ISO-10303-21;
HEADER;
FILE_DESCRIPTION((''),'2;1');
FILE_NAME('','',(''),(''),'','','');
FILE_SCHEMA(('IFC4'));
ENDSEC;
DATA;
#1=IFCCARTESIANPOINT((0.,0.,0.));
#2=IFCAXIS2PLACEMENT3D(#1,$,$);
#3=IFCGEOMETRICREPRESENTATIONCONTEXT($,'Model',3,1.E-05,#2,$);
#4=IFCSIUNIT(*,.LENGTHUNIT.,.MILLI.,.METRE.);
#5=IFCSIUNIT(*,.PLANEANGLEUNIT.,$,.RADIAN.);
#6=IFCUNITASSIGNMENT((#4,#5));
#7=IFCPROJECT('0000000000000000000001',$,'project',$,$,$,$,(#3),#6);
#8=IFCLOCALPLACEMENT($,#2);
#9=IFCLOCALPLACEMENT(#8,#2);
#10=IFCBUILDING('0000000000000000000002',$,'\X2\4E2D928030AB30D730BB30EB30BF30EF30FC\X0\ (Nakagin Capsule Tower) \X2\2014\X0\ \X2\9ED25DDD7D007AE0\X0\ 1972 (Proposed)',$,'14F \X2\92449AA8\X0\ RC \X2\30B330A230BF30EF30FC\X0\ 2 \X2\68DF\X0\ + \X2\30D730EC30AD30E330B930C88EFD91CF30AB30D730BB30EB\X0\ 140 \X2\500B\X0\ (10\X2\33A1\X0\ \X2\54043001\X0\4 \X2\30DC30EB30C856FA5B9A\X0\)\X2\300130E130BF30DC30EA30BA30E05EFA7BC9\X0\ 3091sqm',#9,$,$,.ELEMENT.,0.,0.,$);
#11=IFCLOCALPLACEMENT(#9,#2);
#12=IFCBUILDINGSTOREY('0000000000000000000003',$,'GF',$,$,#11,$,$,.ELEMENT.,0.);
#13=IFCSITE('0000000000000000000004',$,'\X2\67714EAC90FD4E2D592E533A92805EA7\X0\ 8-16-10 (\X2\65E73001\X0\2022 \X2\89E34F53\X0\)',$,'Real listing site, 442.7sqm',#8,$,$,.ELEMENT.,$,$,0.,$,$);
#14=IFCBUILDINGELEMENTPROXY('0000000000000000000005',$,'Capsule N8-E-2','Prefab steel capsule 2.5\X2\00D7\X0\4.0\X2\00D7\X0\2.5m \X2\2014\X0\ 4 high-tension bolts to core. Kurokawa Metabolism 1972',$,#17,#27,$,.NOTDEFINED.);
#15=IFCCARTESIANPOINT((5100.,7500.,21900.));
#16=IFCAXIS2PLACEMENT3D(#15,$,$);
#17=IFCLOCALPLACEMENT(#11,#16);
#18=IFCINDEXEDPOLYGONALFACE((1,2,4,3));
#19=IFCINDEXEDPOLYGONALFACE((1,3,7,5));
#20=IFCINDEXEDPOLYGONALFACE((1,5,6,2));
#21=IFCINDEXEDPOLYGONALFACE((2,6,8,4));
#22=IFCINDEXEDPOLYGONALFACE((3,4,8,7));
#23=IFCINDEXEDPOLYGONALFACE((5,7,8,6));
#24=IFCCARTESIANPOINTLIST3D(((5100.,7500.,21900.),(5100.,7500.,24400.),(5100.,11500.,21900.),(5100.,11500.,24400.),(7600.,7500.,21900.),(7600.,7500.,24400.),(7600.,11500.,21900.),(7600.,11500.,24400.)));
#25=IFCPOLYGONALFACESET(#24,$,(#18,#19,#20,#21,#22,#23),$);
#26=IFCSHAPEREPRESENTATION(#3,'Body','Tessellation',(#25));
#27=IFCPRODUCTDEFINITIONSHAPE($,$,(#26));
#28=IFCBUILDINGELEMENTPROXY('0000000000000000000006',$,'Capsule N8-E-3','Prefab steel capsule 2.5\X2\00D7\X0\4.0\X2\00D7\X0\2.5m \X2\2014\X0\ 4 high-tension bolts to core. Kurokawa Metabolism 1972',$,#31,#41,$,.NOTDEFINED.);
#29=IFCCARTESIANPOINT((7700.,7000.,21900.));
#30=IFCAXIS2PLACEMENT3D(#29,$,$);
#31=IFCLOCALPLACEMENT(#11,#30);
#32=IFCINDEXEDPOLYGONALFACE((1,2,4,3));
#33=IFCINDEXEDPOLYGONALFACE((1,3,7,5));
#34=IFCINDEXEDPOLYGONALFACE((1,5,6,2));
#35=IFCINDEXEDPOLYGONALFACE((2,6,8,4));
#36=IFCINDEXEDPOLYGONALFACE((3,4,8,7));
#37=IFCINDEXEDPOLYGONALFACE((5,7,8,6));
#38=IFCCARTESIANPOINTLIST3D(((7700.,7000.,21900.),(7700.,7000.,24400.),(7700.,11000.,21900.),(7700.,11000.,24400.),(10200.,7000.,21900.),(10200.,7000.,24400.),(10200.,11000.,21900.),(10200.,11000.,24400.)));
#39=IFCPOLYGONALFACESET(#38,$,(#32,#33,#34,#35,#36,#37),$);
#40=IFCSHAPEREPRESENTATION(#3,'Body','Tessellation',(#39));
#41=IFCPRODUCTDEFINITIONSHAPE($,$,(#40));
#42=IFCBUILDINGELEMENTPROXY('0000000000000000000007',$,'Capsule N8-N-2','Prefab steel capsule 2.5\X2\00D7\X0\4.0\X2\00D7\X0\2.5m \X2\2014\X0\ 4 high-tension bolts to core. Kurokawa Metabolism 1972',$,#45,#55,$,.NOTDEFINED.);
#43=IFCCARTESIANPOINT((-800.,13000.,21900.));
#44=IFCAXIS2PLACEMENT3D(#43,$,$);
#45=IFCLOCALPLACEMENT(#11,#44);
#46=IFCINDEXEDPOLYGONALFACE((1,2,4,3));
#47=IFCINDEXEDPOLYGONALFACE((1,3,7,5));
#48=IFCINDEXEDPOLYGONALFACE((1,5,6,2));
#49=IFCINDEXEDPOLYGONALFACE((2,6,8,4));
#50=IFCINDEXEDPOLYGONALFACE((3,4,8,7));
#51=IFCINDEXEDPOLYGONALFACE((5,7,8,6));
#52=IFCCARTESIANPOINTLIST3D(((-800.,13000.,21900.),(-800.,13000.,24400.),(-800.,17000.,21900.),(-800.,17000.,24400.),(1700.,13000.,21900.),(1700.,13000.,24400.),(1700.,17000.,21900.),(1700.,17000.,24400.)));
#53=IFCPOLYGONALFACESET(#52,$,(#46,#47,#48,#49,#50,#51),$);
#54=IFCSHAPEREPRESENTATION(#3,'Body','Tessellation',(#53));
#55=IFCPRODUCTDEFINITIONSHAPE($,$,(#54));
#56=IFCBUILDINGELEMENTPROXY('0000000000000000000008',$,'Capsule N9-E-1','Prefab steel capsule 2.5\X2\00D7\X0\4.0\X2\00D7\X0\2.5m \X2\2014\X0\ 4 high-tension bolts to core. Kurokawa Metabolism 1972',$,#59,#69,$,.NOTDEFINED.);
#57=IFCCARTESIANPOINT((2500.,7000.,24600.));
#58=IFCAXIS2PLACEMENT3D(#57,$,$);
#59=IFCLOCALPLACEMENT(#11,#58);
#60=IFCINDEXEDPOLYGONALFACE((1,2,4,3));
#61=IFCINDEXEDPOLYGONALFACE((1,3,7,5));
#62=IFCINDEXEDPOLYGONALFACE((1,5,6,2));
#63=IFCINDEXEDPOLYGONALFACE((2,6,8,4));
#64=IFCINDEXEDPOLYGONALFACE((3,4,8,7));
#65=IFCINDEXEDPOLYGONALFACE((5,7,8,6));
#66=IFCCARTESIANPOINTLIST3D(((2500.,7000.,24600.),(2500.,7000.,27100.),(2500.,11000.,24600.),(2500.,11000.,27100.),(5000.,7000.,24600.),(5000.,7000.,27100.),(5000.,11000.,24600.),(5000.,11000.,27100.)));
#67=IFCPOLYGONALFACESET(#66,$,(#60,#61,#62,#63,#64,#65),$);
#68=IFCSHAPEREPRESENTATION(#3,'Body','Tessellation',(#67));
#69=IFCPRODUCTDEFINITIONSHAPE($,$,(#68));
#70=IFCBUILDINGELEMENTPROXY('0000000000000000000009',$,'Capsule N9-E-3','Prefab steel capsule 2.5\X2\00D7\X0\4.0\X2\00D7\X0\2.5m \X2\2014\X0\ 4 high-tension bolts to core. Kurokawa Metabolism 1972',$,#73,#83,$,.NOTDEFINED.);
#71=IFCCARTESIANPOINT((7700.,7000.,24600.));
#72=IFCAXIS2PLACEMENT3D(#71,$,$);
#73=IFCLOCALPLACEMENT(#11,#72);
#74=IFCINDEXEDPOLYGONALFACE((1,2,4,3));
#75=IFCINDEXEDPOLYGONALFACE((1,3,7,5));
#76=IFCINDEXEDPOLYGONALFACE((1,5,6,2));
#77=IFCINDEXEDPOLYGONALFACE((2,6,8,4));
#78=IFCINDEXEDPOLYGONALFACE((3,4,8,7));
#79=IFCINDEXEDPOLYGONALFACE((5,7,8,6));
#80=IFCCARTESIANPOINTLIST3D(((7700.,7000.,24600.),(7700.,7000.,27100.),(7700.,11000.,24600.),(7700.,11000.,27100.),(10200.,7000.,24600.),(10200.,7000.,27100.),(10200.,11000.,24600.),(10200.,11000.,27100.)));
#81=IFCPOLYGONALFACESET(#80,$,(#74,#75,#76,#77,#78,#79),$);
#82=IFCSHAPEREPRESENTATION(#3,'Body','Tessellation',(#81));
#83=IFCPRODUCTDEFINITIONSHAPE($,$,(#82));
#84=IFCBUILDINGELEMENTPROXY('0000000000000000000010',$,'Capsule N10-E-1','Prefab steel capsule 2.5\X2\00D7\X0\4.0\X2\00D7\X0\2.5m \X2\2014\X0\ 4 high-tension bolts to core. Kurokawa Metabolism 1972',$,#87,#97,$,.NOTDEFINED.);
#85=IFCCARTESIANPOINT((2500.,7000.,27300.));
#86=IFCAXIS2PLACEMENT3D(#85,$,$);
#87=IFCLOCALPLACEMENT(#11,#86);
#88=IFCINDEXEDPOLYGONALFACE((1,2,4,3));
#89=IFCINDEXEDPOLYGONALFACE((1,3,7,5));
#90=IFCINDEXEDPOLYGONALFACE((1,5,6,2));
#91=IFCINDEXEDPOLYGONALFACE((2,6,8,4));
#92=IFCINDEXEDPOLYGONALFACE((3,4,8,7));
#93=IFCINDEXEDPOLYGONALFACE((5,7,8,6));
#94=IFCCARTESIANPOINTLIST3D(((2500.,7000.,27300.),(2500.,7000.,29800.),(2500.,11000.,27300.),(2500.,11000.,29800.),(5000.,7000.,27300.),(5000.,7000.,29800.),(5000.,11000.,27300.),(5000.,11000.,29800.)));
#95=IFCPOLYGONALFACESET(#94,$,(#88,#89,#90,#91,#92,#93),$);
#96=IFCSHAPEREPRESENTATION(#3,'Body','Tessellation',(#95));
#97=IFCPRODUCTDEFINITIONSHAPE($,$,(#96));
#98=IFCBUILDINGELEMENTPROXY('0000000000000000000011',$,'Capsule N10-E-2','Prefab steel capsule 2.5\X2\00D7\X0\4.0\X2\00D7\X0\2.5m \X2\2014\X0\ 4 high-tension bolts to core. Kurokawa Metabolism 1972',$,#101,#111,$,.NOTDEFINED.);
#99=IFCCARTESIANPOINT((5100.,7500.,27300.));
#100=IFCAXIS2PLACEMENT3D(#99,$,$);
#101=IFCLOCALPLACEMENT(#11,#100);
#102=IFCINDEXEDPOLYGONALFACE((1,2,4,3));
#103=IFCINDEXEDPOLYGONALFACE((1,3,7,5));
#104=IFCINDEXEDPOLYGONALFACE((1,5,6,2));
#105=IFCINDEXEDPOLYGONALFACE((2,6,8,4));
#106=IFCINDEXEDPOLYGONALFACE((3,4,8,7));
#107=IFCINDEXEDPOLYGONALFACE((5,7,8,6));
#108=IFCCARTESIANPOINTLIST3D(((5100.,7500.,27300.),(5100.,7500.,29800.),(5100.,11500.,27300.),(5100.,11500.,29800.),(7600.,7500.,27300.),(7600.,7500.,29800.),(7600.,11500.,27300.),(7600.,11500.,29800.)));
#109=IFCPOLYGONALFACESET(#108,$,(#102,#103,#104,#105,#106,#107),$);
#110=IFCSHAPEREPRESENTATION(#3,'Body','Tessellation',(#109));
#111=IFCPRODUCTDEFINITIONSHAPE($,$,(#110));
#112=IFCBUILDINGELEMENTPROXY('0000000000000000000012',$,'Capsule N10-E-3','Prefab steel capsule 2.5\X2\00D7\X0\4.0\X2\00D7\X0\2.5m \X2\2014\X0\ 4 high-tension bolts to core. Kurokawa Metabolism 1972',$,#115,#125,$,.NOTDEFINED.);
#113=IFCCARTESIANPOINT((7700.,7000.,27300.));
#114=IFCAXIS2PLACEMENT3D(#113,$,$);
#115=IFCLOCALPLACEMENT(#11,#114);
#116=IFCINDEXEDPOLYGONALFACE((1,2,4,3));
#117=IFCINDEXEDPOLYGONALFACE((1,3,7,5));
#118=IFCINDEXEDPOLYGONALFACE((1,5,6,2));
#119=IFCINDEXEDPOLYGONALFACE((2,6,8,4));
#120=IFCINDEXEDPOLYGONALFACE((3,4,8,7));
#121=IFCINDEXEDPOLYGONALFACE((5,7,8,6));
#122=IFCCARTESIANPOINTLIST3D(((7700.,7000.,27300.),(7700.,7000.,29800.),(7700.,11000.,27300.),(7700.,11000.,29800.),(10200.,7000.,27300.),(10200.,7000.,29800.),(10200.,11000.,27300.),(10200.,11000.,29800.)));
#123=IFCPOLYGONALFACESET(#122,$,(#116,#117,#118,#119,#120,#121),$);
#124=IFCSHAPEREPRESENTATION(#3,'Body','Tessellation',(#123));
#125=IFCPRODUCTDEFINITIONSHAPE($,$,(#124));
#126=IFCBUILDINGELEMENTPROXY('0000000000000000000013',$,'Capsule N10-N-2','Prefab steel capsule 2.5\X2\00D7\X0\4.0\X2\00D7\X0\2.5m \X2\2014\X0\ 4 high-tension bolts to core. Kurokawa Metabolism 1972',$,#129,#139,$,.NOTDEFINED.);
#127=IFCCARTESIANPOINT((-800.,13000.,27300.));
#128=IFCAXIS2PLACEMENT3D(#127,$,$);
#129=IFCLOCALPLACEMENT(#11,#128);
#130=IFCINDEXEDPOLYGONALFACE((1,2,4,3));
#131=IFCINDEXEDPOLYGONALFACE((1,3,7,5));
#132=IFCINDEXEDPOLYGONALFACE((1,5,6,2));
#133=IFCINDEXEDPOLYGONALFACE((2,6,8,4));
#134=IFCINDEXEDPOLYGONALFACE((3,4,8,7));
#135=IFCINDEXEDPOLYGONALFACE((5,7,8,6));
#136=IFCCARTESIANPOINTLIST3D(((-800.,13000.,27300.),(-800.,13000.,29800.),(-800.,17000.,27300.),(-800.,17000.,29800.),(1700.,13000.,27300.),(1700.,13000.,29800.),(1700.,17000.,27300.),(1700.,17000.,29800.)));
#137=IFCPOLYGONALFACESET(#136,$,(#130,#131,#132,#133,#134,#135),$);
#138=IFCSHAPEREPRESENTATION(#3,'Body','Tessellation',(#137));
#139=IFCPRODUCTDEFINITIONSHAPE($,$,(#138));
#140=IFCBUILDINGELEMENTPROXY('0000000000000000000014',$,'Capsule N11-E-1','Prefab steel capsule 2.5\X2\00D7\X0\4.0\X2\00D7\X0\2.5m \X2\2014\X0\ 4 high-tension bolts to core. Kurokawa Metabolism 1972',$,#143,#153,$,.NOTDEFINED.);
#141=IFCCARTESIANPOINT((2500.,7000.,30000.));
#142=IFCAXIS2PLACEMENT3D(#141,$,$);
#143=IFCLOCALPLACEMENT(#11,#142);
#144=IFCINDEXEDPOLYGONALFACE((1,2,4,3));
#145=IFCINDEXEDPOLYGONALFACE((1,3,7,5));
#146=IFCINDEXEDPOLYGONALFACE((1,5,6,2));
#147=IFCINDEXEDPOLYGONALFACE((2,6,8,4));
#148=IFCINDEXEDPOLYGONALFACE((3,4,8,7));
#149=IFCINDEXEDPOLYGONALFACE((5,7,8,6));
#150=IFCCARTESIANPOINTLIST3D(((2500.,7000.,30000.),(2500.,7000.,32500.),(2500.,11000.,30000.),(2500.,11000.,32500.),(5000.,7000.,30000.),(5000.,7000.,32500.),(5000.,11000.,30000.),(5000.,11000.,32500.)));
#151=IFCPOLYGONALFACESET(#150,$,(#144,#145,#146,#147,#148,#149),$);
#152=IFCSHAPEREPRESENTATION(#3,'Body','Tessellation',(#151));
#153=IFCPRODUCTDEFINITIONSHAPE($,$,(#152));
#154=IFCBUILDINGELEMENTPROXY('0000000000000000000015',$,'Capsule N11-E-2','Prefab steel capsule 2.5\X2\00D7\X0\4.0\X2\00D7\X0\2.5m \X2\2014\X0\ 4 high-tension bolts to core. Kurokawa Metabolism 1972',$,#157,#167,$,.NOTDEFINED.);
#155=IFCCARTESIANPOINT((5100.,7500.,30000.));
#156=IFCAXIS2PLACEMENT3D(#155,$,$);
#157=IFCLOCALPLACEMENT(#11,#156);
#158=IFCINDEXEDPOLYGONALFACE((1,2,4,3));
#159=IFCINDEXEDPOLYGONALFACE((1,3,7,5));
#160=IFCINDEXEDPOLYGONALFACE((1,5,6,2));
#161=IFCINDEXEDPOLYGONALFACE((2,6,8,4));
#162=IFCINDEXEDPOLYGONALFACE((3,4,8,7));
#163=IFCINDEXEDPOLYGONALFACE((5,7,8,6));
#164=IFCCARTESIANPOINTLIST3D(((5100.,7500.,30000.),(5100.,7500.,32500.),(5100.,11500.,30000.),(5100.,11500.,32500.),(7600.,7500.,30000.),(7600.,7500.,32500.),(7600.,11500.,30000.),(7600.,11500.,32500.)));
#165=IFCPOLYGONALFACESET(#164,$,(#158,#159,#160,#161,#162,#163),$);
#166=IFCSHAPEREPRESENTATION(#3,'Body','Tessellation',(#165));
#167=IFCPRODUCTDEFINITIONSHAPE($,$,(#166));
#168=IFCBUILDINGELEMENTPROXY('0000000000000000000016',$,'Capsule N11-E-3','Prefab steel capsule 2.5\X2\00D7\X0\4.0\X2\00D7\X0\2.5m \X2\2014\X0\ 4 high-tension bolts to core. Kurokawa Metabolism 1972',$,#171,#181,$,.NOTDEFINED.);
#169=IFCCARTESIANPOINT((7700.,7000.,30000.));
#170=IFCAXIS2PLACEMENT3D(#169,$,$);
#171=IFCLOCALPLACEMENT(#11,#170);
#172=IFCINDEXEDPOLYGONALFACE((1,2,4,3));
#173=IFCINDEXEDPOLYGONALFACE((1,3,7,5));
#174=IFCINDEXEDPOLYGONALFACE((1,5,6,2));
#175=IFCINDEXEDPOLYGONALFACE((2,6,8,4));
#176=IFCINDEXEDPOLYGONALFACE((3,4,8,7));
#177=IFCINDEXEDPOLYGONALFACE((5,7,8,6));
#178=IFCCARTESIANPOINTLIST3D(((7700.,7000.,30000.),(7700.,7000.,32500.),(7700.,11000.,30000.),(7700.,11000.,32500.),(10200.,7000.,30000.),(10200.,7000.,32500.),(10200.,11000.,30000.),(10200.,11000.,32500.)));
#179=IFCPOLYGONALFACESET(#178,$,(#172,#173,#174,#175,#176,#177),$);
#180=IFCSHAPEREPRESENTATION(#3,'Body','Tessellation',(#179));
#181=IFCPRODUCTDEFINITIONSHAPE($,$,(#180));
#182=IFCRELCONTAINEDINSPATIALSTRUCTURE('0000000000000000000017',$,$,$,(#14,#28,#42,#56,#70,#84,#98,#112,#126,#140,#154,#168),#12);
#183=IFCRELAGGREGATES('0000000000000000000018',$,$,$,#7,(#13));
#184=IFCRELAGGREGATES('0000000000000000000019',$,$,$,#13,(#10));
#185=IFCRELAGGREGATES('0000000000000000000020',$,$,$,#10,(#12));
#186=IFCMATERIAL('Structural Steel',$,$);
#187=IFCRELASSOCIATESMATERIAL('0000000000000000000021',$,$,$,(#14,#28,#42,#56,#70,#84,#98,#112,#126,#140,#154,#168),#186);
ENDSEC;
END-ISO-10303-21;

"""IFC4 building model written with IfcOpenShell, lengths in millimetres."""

from ifc_helpers import new_model, si_unit, frame, frame_2d, origin, place, context, project, spatial, rectangle, extrude, material, element, save


model = new_model("IFC4")

# Units and contexts
model_context = context("Model", 3, precision=1e-05, world=origin())
ifc_project = project(units=[si_unit("LENGTHUNIT", "METRE", prefix="MILLI"), si_unit("PLANEANGLEUNIT", "RADIAN")], contexts=[model_context])

# Site, building, storey
site_placement = place(None, origin())
site = spatial("IfcSite", under=ifc_project, at=site_placement, Name="東京都中央区銀座 8-16-10 (旧、2022 解体)", ObjectType="Real listing site, 442.7sqm", CompositionType="ELEMENT", RefElevation=0.0)
building_placement = place(site_placement, origin())
building = spatial("IfcBuilding", under=site, at=building_placement, Name="中銀カプセルタワー (Nakagin Capsule Tower) — 黒川紀章 1972 (Proposed)", ObjectType="14F 鉄骨 RC コアタワー 2 棟 + プレキャスト軽量カプセル 140 個 (10㎡ 各、4 ボルト固定)、メタボリズム建築 3091sqm", CompositionType="ELEMENT", ElevationOfRefHeight=0.0, ElevationOfTerrain=0.0)
storey_placement = place(building_placement, origin())
storey = spatial("IfcBuildingStorey", under=building, at=storey_placement, Name="GF", CompositionType="ELEMENT", Elevation=0.0)

# Shared definitions
ifc_material_1 = material(Name="Structural Steel")

# Building element proxies
proxy_1_placement = place(storey_placement, frame((5100.0, 7500.0, 21900.0)))
element("IfcBuildingElementProxy", 1, at=proxy_1_placement, inside=storey, material=ifc_material_1, Name="Capsule N8-E-2", Description="Prefab steel capsule 2.5×4.0×2.5m — 4 high-tension bolts to core. Kurokawa Metabolism 1972", PredefinedType="NOTDEFINED", context=model_context, shape_type="SweptSolid", body=[
    extrude(rectangle(XDim=2500.0, YDim=4000.0, at=frame_2d((1250.0, 2000.0))), frame((5100.0, 7500.0, 21900.0)), (0.0, 0.0, 1.0), 2500.0),
])
proxy_2_placement = place(storey_placement, frame((7700.0, 7000.0, 21900.0)))
element("IfcBuildingElementProxy", 2, at=proxy_2_placement, inside=storey, material=ifc_material_1, Name="Capsule N8-E-3", Description="Prefab steel capsule 2.5×4.0×2.5m — 4 high-tension bolts to core. Kurokawa Metabolism 1972", PredefinedType="NOTDEFINED", context=model_context, shape_type="SweptSolid", body=[
    extrude(rectangle(XDim=2500.0, YDim=4000.0, at=frame_2d((1250.0, 2000.0))), frame((7700.0, 7000.0, 21900.0)), (0.0, 0.0, 1.0), 2500.0),
])
proxy_3_placement = place(storey_placement, frame((-800.0, 13000.0, 21900.0)))
element("IfcBuildingElementProxy", 3, at=proxy_3_placement, inside=storey, material=ifc_material_1, Name="Capsule N8-N-2", Description="Prefab steel capsule 2.5×4.0×2.5m — 4 high-tension bolts to core. Kurokawa Metabolism 1972", PredefinedType="NOTDEFINED", context=model_context, shape_type="SweptSolid", body=[
    extrude(rectangle(XDim=2500.0, YDim=4000.0, at=frame_2d((1250.0, 2000.0))), frame((-800.0, 13000.0, 21900.0)), (0.0, 0.0, 1.0), 2500.0),
])
proxy_4_placement = place(storey_placement, frame((2500.0, 7000.0, 24600.0)))
element("IfcBuildingElementProxy", 4, at=proxy_4_placement, inside=storey, material=ifc_material_1, Name="Capsule N9-E-1", Description="Prefab steel capsule 2.5×4.0×2.5m — 4 high-tension bolts to core. Kurokawa Metabolism 1972", PredefinedType="NOTDEFINED", context=model_context, shape_type="SweptSolid", body=[
    extrude(rectangle(XDim=2500.0, YDim=4000.0, at=frame_2d((1250.0, 2000.0))), frame((2500.0, 7000.0, 24600.0)), (0.0, 0.0, 1.0), 2500.0),
])
proxy_5_placement = place(storey_placement, frame((7700.0, 7000.0, 24600.0)))
element("IfcBuildingElementProxy", 5, at=proxy_5_placement, inside=storey, material=ifc_material_1, Name="Capsule N9-E-3", Description="Prefab steel capsule 2.5×4.0×2.5m — 4 high-tension bolts to core. Kurokawa Metabolism 1972", PredefinedType="NOTDEFINED", context=model_context, shape_type="SweptSolid", body=[
    extrude(rectangle(XDim=2500.0, YDim=4000.0, at=frame_2d((1250.0, 2000.0))), frame((7700.0, 7000.0, 24600.0)), (0.0, 0.0, 1.0), 2500.0),
])
proxy_6_placement = place(storey_placement, frame((2500.0, 7000.0, 27300.0)))
element("IfcBuildingElementProxy", 6, at=proxy_6_placement, inside=storey, material=ifc_material_1, Name="Capsule N10-E-1", Description="Prefab steel capsule 2.5×4.0×2.5m — 4 high-tension bolts to core. Kurokawa Metabolism 1972", PredefinedType="NOTDEFINED", context=model_context, shape_type="SweptSolid", body=[
    extrude(rectangle(XDim=2500.0, YDim=4000.0, at=frame_2d((1250.0, 2000.0))), frame((2500.0, 7000.0, 27300.0)), (0.0, 0.0, 1.0), 2500.0),
])
proxy_7_placement = place(storey_placement, frame((5100.0, 7500.0, 27300.0)))
element("IfcBuildingElementProxy", 7, at=proxy_7_placement, inside=storey, material=ifc_material_1, Name="Capsule N10-E-2", Description="Prefab steel capsule 2.5×4.0×2.5m — 4 high-tension bolts to core. Kurokawa Metabolism 1972", PredefinedType="NOTDEFINED", context=model_context, shape_type="SweptSolid", body=[
    extrude(rectangle(XDim=2500.0, YDim=4000.0, at=frame_2d((1250.0, 2000.0))), frame((5100.0, 7500.0, 27300.0)), (0.0, 0.0, 1.0), 2500.0),
])
proxy_8_placement = place(storey_placement, frame((7700.0, 7000.0, 27300.0)))
element("IfcBuildingElementProxy", 8, at=proxy_8_placement, inside=storey, material=ifc_material_1, Name="Capsule N10-E-3", Description="Prefab steel capsule 2.5×4.0×2.5m — 4 high-tension bolts to core. Kurokawa Metabolism 1972", PredefinedType="NOTDEFINED", context=model_context, shape_type="SweptSolid", body=[
    extrude(rectangle(XDim=2500.0, YDim=4000.0, at=frame_2d((1250.0, 2000.0))), frame((7700.0, 7000.0, 27300.0)), (0.0, 0.0, 1.0), 2500.0),
])
proxy_9_placement = place(storey_placement, frame((-800.0, 13000.0, 27300.0)))
element("IfcBuildingElementProxy", 9, at=proxy_9_placement, inside=storey, material=ifc_material_1, Name="Capsule N10-N-2", Description="Prefab steel capsule 2.5×4.0×2.5m — 4 high-tension bolts to core. Kurokawa Metabolism 1972", PredefinedType="NOTDEFINED", context=model_context, shape_type="SweptSolid", body=[
    extrude(rectangle(XDim=2500.0, YDim=4000.0, at=frame_2d((1250.0, 2000.0))), frame((-800.0, 13000.0, 27300.0)), (0.0, 0.0, 1.0), 2500.0),
])
proxy_10_placement = place(storey_placement, frame((2500.0, 7000.0, 30000.0)))
element("IfcBuildingElementProxy", 10, at=proxy_10_placement, inside=storey, material=ifc_material_1, Name="Capsule N11-E-1", Description="Prefab steel capsule 2.5×4.0×2.5m — 4 high-tension bolts to core. Kurokawa Metabolism 1972", PredefinedType="NOTDEFINED", context=model_context, shape_type="SweptSolid", body=[
    extrude(rectangle(XDim=2500.0, YDim=4000.0, at=frame_2d((1250.0, 2000.0))), frame((2500.0, 7000.0, 30000.0)), (0.0, 0.0, 1.0), 2500.0),
])
proxy_11_placement = place(storey_placement, frame((5100.0, 7500.0, 30000.0)))
element("IfcBuildingElementProxy", 11, at=proxy_11_placement, inside=storey, material=ifc_material_1, Name="Capsule N11-E-2", Description="Prefab steel capsule 2.5×4.0×2.5m — 4 high-tension bolts to core. Kurokawa Metabolism 1972", PredefinedType="NOTDEFINED", context=model_context, shape_type="SweptSolid", body=[
    extrude(rectangle(XDim=2500.0, YDim=4000.0, at=frame_2d((1250.0, 2000.0))), frame((5100.0, 7500.0, 30000.0)), (0.0, 0.0, 1.0), 2500.0),
])
proxy_12_placement = place(storey_placement, frame((7700.0, 7000.0, 30000.0)))
element("IfcBuildingElementProxy", 12, at=proxy_12_placement, inside=storey, material=ifc_material_1, Name="Capsule N11-E-3", Description="Prefab steel capsule 2.5×4.0×2.5m — 4 high-tension bolts to core. Kurokawa Metabolism 1972", PredefinedType="NOTDEFINED", context=model_context, shape_type="SweptSolid", body=[
    extrude(rectangle(XDim=2500.0, YDim=4000.0, at=frame_2d((1250.0, 2000.0))), frame((7700.0, 7000.0, 30000.0)), (0.0, 0.0, 1.0), 2500.0),
])

save(model, "model.ifc")
